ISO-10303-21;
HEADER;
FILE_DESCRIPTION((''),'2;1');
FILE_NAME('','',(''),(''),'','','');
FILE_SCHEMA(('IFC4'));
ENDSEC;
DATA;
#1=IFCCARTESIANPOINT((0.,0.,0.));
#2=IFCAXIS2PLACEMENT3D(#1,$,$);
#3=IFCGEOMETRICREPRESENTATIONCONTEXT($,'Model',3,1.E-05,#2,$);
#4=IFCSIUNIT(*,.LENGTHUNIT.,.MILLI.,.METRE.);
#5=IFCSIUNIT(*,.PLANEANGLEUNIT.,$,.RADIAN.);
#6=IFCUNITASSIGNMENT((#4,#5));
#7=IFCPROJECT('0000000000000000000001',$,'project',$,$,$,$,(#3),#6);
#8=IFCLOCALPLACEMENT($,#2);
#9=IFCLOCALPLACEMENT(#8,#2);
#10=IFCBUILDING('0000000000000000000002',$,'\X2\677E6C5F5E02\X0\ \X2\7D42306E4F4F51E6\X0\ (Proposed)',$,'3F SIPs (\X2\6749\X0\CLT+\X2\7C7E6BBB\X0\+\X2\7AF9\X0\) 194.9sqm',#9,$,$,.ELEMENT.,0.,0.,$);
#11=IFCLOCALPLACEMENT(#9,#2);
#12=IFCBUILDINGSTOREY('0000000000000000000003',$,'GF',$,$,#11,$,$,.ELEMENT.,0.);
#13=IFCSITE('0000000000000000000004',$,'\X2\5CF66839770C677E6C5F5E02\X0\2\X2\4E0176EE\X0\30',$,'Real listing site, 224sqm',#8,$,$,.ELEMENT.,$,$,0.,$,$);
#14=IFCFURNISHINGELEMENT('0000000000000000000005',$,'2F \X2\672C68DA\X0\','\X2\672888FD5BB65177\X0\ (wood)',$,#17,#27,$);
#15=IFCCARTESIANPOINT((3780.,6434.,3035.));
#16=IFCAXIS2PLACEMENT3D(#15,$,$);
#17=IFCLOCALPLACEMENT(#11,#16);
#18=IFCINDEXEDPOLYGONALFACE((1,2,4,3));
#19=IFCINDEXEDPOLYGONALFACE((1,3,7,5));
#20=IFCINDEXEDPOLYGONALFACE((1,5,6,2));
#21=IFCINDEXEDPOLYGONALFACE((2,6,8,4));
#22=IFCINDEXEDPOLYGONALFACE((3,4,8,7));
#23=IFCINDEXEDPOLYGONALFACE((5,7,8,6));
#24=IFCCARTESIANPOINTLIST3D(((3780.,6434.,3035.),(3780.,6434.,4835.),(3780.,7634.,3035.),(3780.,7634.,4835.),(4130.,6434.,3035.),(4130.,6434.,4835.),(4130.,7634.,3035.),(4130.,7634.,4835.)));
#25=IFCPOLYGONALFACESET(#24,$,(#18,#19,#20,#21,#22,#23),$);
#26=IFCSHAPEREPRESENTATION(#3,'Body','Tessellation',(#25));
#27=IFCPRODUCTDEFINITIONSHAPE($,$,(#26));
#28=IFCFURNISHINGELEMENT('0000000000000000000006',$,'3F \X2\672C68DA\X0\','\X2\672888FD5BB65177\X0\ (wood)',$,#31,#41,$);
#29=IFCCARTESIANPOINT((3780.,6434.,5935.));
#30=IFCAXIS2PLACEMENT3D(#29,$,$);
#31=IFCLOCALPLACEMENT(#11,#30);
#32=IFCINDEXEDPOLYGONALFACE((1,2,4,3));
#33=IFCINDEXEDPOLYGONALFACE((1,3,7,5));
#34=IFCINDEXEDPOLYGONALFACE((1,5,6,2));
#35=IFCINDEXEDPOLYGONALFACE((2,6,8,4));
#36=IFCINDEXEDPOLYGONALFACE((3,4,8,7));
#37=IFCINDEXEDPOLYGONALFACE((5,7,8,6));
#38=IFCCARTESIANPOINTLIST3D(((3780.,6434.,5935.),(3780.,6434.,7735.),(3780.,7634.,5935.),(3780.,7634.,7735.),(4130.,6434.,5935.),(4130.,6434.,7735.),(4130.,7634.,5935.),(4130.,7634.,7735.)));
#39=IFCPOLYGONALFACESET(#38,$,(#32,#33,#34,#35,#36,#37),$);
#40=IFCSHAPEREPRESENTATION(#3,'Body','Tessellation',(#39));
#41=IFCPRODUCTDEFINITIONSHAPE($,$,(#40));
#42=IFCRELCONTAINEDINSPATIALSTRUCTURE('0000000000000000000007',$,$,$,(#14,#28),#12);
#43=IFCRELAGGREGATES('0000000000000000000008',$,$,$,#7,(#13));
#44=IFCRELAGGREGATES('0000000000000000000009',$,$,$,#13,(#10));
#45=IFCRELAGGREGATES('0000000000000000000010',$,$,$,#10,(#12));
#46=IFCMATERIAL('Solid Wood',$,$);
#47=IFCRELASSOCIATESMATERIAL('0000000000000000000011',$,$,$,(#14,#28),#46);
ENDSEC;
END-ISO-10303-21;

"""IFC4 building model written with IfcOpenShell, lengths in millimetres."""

from ifc_helpers import new_model, si_unit, frame, frame_2d, origin, place, context, project, spatial, rectangle, extrude, material, element, save


model = new_model("IFC4")

# Units and contexts
model_context = context("Model", 3, precision=1e-05, world=origin())
ifc_project = project(units=[si_unit("LENGTHUNIT", "METRE", prefix="MILLI"), si_unit("PLANEANGLEUNIT", "RADIAN")], contexts=[model_context])

# Site, building, storey
site_placement = place(None, origin())
site = spatial("IfcSite", under=ifc_project, at=site_placement, Name="島根県松江市2丁目30", ObjectType="Real listing site, 224sqm", CompositionType="ELEMENT", RefElevation=0.0)
building_placement = place(site_placement, origin())
building = spatial("IfcBuilding", under=site, at=building_placement, Name="松江市 終の住処 (Proposed)", ObjectType="3F SIPs (杉CLT+籾殻+竹) 194.9sqm", CompositionType="ELEMENT", ElevationOfRefHeight=0.0, ElevationOfTerrain=0.0)
storey_placement = place(building_placement, origin())
storey = spatial("IfcBuildingStorey", under=building, at=storey_placement, Name="GF", CompositionType="ELEMENT", Elevation=0.0)

# Shared definitions
ifc_material_1 = material(Name="Solid Wood")

# Furnishing elements
furnishing_1_placement = place(storey_placement, frame((3780.0, 6434.0, 3035.0)))
element("IfcFurnishingElement", 1, at=furnishing_1_placement, inside=storey, material=ifc_material_1, Name="2F 本棚", Description="木製家具 (wood)", context=model_context, shape_type="SweptSolid", body=[
    extrude(rectangle(XDim=350.0, YDim=1200.0, at=frame_2d((175.0, 600.0))), frame((3780.0, 6434.0, 3035.0)), (0.0, 0.0, 1.0), 1800.0),
])
furnishing_2_placement = place(storey_placement, frame((3780.0, 6434.0, 5935.0)))
element("IfcFurnishingElement", 2, at=furnishing_2_placement, inside=storey, material=ifc_material_1, Name="3F 本棚", Description="木製家具 (wood)", context=model_context, shape_type="SweptSolid", body=[
    extrude(rectangle(XDim=350.0, YDim=1200.0, at=frame_2d((175.0, 600.0))), frame((3780.0, 6434.0, 5935.0)), (0.0, 0.0, 1.0), 1800.0),
])

save(model, "model.ifc")
